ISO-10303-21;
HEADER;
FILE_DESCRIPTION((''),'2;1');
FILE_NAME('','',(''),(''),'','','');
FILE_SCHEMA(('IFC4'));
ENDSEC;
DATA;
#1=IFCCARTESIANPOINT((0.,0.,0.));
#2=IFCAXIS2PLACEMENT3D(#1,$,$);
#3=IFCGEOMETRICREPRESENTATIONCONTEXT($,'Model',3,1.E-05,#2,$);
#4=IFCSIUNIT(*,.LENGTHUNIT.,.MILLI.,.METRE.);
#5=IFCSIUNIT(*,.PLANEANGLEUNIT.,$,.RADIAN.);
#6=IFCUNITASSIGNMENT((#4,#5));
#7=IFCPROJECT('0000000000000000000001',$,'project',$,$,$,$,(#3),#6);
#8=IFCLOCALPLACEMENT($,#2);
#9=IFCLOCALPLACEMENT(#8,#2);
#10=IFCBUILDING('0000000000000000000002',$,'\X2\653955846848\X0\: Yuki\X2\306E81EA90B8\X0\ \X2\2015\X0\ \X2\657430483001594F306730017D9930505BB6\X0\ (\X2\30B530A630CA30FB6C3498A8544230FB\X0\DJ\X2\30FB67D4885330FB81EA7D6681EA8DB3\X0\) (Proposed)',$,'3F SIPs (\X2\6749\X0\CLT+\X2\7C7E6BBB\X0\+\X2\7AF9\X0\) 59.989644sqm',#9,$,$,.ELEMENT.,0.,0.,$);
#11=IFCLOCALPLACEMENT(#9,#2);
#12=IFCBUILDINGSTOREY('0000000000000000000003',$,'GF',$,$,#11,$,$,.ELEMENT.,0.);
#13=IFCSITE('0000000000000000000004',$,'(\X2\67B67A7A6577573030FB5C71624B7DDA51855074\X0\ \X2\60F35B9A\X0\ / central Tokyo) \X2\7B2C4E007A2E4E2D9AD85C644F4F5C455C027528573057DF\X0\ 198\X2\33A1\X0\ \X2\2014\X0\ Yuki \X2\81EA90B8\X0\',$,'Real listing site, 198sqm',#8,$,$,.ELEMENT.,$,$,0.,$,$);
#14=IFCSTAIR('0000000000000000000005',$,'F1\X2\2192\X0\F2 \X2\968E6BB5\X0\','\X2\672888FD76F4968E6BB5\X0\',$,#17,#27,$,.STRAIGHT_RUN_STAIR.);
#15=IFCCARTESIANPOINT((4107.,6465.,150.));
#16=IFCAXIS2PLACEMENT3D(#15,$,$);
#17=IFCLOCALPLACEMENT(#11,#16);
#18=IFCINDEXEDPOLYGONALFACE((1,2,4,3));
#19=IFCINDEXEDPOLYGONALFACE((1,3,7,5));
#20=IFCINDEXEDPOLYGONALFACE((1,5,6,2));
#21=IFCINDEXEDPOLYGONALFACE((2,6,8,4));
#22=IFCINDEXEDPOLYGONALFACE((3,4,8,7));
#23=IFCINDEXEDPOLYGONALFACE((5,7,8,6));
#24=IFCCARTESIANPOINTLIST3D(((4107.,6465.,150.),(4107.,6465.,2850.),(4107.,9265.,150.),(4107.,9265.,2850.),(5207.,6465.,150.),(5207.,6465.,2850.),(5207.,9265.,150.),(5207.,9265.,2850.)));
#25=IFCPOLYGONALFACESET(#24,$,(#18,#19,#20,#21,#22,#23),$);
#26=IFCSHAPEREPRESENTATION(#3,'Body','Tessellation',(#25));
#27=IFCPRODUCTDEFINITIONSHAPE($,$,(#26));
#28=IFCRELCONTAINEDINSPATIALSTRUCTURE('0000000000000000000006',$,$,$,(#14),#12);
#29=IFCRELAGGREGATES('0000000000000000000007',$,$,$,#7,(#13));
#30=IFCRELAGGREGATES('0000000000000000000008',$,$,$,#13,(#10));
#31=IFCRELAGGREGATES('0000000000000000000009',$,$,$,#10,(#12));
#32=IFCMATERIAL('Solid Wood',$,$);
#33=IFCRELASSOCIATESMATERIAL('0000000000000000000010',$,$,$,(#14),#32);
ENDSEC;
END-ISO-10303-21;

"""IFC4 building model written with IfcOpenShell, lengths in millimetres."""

from ifc_helpers import new_model, si_unit, frame, frame_2d, origin, place, context, project, spatial, rectangle, extrude, material, element, save


model = new_model("IFC4")

# Units and contexts
model_context = context("Model", 3, precision=1e-05, world=origin())
ifc_project = project(units=[si_unit("LENGTHUNIT", "METRE", prefix="MILLI"), si_unit("PLANEANGLEUNIT", "RADIAN")], contexts=[model_context])

# Site, building, storey
site_placement = place(None, origin())
site = spatial("IfcSite", under=ifc_project, at=site_placement, Name="(架空敷地・山手線内側 想定 / central Tokyo) 第一種中高層住居専用地域 198㎡ — Yuki 自邸", ObjectType="Real listing site, 198sqm", CompositionType="ELEMENT", RefElevation=0.0)
building_placement = place(site_placement, origin())
building = spatial("IfcBuilding", under=site, at=building_placement, Name="改善案: Yukiの自邸 ― 整え、奏で、継ぐ家 (サウナ・水風呂・DJ・柔術・自給自足) (Proposed)", ObjectType="3F SIPs (杉CLT+籾殻+竹) 59.989644sqm", CompositionType="ELEMENT", ElevationOfRefHeight=0.0, ElevationOfTerrain=0.0)
storey_placement = place(building_placement, origin())
storey = spatial("IfcBuildingStorey", under=building, at=storey_placement, Name="GF", CompositionType="ELEMENT", Elevation=0.0)

# Shared definitions
ifc_material_1 = material(Name="Solid Wood")

# Stair
stair_placement = place(storey_placement, frame((4107.0, 6465.0, 150.0)))
element("IfcStair", 1, at=stair_placement, inside=storey, material=ifc_material_1, Name="F1→F2 階段", Description="木製直階段", PredefinedType="STRAIGHT_RUN_STAIR", context=model_context, shape_type="SweptSolid", body=[
    extrude(rectangle(XDim=1100.0, YDim=2800.0, at=frame_2d((550.0, 1400.0))), frame((4107.0, 6465.0, 150.0)), (0.0, 0.0, 1.0), 2700.0),
])

save(model, "model.ifc")
